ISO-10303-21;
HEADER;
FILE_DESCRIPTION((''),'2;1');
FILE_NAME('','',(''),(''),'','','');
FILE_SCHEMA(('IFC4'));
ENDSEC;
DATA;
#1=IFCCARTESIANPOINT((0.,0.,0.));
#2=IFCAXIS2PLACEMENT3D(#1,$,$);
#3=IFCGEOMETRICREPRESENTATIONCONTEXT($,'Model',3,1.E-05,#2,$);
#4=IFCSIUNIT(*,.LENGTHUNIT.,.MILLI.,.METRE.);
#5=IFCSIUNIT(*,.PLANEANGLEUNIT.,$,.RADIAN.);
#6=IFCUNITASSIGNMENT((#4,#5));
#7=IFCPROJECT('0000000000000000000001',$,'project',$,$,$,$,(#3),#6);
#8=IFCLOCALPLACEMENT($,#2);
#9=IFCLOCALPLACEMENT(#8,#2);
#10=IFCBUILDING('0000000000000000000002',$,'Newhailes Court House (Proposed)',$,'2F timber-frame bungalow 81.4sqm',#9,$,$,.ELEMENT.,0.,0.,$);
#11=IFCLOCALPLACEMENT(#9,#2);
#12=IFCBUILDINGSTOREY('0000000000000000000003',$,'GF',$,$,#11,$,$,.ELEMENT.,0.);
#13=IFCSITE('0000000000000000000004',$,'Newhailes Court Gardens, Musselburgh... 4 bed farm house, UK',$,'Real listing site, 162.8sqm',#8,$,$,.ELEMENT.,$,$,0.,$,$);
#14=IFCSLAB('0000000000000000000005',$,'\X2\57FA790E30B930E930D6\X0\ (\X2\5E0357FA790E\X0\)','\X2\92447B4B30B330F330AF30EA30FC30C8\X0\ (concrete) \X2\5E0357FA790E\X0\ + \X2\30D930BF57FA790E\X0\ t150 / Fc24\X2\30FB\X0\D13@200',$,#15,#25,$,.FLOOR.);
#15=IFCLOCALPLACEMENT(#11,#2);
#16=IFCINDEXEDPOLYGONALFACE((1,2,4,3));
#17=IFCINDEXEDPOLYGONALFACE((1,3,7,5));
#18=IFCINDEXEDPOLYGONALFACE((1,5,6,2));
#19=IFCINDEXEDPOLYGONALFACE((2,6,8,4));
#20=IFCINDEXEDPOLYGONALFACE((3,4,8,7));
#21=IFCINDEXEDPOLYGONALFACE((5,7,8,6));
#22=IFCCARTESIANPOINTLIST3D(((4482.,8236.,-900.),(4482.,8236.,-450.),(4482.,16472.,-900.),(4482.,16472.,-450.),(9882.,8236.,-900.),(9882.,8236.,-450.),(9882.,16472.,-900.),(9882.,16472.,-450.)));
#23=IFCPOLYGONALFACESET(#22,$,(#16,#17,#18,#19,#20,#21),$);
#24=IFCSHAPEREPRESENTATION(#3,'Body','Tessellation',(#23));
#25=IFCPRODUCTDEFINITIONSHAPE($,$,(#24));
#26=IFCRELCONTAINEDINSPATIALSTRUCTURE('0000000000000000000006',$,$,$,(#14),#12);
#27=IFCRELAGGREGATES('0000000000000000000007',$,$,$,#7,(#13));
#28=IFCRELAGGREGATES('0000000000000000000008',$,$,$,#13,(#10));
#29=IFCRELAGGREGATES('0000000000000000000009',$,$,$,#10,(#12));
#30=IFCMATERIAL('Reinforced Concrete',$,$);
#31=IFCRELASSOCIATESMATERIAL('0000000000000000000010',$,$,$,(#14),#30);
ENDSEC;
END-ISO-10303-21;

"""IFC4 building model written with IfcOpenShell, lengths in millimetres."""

from ifc_helpers import new_model, si_unit, frame, frame_2d, origin, place, context, project, spatial, rectangle, extrude, material, element, save


model = new_model("IFC4")

# Units and contexts
model_context = context("Model", 3, precision=1e-05, world=origin())
ifc_project = project(units=[si_unit("LENGTHUNIT", "METRE", prefix="MILLI"), si_unit("PLANEANGLEUNIT", "RADIAN")], contexts=[model_context])

# Site, building, storey
site_placement = place(None, origin())
site = spatial("IfcSite", under=ifc_project, at=site_placement, Name="Newhailes Court Gardens, Musselburgh... 4 bed farm house, UK", ObjectType="Real listing site, 162.8sqm", CompositionType="ELEMENT", RefElevation=0.0)
building_placement = place(site_placement, origin())
building = spatial("IfcBuilding", under=site, at=building_placement, Name="Newhailes Court House (Proposed)", ObjectType="2F timber-frame bungalow 81.4sqm", CompositionType="ELEMENT", ElevationOfRefHeight=0.0, ElevationOfTerrain=0.0)
storey_placement = place(building_placement, origin())
storey = spatial("IfcBuildingStorey", under=building, at=storey_placement, Name="GF", CompositionType="ELEMENT", Elevation=0.0)

# Slab
ifc_material_1 = material(Name="Reinforced Concrete")
slab_1_placement = place(storey_placement, frame((2241.0, 4118.0, -450.0)))
element("IfcSlab", 1, at=slab_1_placement, inside=storey, material=ifc_material_1, Name="基礎スラブ (布基礎)", Description="鉄筋コンクリート (concrete) 布基礎 + ベタ基礎 t150 / Fc24・D13@200", PredefinedType="FLOOR", context=model_context, shape_type="SweptSolid", body=[
    extrude(rectangle(XDim=5400.0, YDim=8236.0, at=frame_2d((2700.0, 4118.0))), frame((2241.0, 4118.0, -450.0)), (0.0, 0.0, 1.0), 450.0),
])

save(model, "model.ifc")
